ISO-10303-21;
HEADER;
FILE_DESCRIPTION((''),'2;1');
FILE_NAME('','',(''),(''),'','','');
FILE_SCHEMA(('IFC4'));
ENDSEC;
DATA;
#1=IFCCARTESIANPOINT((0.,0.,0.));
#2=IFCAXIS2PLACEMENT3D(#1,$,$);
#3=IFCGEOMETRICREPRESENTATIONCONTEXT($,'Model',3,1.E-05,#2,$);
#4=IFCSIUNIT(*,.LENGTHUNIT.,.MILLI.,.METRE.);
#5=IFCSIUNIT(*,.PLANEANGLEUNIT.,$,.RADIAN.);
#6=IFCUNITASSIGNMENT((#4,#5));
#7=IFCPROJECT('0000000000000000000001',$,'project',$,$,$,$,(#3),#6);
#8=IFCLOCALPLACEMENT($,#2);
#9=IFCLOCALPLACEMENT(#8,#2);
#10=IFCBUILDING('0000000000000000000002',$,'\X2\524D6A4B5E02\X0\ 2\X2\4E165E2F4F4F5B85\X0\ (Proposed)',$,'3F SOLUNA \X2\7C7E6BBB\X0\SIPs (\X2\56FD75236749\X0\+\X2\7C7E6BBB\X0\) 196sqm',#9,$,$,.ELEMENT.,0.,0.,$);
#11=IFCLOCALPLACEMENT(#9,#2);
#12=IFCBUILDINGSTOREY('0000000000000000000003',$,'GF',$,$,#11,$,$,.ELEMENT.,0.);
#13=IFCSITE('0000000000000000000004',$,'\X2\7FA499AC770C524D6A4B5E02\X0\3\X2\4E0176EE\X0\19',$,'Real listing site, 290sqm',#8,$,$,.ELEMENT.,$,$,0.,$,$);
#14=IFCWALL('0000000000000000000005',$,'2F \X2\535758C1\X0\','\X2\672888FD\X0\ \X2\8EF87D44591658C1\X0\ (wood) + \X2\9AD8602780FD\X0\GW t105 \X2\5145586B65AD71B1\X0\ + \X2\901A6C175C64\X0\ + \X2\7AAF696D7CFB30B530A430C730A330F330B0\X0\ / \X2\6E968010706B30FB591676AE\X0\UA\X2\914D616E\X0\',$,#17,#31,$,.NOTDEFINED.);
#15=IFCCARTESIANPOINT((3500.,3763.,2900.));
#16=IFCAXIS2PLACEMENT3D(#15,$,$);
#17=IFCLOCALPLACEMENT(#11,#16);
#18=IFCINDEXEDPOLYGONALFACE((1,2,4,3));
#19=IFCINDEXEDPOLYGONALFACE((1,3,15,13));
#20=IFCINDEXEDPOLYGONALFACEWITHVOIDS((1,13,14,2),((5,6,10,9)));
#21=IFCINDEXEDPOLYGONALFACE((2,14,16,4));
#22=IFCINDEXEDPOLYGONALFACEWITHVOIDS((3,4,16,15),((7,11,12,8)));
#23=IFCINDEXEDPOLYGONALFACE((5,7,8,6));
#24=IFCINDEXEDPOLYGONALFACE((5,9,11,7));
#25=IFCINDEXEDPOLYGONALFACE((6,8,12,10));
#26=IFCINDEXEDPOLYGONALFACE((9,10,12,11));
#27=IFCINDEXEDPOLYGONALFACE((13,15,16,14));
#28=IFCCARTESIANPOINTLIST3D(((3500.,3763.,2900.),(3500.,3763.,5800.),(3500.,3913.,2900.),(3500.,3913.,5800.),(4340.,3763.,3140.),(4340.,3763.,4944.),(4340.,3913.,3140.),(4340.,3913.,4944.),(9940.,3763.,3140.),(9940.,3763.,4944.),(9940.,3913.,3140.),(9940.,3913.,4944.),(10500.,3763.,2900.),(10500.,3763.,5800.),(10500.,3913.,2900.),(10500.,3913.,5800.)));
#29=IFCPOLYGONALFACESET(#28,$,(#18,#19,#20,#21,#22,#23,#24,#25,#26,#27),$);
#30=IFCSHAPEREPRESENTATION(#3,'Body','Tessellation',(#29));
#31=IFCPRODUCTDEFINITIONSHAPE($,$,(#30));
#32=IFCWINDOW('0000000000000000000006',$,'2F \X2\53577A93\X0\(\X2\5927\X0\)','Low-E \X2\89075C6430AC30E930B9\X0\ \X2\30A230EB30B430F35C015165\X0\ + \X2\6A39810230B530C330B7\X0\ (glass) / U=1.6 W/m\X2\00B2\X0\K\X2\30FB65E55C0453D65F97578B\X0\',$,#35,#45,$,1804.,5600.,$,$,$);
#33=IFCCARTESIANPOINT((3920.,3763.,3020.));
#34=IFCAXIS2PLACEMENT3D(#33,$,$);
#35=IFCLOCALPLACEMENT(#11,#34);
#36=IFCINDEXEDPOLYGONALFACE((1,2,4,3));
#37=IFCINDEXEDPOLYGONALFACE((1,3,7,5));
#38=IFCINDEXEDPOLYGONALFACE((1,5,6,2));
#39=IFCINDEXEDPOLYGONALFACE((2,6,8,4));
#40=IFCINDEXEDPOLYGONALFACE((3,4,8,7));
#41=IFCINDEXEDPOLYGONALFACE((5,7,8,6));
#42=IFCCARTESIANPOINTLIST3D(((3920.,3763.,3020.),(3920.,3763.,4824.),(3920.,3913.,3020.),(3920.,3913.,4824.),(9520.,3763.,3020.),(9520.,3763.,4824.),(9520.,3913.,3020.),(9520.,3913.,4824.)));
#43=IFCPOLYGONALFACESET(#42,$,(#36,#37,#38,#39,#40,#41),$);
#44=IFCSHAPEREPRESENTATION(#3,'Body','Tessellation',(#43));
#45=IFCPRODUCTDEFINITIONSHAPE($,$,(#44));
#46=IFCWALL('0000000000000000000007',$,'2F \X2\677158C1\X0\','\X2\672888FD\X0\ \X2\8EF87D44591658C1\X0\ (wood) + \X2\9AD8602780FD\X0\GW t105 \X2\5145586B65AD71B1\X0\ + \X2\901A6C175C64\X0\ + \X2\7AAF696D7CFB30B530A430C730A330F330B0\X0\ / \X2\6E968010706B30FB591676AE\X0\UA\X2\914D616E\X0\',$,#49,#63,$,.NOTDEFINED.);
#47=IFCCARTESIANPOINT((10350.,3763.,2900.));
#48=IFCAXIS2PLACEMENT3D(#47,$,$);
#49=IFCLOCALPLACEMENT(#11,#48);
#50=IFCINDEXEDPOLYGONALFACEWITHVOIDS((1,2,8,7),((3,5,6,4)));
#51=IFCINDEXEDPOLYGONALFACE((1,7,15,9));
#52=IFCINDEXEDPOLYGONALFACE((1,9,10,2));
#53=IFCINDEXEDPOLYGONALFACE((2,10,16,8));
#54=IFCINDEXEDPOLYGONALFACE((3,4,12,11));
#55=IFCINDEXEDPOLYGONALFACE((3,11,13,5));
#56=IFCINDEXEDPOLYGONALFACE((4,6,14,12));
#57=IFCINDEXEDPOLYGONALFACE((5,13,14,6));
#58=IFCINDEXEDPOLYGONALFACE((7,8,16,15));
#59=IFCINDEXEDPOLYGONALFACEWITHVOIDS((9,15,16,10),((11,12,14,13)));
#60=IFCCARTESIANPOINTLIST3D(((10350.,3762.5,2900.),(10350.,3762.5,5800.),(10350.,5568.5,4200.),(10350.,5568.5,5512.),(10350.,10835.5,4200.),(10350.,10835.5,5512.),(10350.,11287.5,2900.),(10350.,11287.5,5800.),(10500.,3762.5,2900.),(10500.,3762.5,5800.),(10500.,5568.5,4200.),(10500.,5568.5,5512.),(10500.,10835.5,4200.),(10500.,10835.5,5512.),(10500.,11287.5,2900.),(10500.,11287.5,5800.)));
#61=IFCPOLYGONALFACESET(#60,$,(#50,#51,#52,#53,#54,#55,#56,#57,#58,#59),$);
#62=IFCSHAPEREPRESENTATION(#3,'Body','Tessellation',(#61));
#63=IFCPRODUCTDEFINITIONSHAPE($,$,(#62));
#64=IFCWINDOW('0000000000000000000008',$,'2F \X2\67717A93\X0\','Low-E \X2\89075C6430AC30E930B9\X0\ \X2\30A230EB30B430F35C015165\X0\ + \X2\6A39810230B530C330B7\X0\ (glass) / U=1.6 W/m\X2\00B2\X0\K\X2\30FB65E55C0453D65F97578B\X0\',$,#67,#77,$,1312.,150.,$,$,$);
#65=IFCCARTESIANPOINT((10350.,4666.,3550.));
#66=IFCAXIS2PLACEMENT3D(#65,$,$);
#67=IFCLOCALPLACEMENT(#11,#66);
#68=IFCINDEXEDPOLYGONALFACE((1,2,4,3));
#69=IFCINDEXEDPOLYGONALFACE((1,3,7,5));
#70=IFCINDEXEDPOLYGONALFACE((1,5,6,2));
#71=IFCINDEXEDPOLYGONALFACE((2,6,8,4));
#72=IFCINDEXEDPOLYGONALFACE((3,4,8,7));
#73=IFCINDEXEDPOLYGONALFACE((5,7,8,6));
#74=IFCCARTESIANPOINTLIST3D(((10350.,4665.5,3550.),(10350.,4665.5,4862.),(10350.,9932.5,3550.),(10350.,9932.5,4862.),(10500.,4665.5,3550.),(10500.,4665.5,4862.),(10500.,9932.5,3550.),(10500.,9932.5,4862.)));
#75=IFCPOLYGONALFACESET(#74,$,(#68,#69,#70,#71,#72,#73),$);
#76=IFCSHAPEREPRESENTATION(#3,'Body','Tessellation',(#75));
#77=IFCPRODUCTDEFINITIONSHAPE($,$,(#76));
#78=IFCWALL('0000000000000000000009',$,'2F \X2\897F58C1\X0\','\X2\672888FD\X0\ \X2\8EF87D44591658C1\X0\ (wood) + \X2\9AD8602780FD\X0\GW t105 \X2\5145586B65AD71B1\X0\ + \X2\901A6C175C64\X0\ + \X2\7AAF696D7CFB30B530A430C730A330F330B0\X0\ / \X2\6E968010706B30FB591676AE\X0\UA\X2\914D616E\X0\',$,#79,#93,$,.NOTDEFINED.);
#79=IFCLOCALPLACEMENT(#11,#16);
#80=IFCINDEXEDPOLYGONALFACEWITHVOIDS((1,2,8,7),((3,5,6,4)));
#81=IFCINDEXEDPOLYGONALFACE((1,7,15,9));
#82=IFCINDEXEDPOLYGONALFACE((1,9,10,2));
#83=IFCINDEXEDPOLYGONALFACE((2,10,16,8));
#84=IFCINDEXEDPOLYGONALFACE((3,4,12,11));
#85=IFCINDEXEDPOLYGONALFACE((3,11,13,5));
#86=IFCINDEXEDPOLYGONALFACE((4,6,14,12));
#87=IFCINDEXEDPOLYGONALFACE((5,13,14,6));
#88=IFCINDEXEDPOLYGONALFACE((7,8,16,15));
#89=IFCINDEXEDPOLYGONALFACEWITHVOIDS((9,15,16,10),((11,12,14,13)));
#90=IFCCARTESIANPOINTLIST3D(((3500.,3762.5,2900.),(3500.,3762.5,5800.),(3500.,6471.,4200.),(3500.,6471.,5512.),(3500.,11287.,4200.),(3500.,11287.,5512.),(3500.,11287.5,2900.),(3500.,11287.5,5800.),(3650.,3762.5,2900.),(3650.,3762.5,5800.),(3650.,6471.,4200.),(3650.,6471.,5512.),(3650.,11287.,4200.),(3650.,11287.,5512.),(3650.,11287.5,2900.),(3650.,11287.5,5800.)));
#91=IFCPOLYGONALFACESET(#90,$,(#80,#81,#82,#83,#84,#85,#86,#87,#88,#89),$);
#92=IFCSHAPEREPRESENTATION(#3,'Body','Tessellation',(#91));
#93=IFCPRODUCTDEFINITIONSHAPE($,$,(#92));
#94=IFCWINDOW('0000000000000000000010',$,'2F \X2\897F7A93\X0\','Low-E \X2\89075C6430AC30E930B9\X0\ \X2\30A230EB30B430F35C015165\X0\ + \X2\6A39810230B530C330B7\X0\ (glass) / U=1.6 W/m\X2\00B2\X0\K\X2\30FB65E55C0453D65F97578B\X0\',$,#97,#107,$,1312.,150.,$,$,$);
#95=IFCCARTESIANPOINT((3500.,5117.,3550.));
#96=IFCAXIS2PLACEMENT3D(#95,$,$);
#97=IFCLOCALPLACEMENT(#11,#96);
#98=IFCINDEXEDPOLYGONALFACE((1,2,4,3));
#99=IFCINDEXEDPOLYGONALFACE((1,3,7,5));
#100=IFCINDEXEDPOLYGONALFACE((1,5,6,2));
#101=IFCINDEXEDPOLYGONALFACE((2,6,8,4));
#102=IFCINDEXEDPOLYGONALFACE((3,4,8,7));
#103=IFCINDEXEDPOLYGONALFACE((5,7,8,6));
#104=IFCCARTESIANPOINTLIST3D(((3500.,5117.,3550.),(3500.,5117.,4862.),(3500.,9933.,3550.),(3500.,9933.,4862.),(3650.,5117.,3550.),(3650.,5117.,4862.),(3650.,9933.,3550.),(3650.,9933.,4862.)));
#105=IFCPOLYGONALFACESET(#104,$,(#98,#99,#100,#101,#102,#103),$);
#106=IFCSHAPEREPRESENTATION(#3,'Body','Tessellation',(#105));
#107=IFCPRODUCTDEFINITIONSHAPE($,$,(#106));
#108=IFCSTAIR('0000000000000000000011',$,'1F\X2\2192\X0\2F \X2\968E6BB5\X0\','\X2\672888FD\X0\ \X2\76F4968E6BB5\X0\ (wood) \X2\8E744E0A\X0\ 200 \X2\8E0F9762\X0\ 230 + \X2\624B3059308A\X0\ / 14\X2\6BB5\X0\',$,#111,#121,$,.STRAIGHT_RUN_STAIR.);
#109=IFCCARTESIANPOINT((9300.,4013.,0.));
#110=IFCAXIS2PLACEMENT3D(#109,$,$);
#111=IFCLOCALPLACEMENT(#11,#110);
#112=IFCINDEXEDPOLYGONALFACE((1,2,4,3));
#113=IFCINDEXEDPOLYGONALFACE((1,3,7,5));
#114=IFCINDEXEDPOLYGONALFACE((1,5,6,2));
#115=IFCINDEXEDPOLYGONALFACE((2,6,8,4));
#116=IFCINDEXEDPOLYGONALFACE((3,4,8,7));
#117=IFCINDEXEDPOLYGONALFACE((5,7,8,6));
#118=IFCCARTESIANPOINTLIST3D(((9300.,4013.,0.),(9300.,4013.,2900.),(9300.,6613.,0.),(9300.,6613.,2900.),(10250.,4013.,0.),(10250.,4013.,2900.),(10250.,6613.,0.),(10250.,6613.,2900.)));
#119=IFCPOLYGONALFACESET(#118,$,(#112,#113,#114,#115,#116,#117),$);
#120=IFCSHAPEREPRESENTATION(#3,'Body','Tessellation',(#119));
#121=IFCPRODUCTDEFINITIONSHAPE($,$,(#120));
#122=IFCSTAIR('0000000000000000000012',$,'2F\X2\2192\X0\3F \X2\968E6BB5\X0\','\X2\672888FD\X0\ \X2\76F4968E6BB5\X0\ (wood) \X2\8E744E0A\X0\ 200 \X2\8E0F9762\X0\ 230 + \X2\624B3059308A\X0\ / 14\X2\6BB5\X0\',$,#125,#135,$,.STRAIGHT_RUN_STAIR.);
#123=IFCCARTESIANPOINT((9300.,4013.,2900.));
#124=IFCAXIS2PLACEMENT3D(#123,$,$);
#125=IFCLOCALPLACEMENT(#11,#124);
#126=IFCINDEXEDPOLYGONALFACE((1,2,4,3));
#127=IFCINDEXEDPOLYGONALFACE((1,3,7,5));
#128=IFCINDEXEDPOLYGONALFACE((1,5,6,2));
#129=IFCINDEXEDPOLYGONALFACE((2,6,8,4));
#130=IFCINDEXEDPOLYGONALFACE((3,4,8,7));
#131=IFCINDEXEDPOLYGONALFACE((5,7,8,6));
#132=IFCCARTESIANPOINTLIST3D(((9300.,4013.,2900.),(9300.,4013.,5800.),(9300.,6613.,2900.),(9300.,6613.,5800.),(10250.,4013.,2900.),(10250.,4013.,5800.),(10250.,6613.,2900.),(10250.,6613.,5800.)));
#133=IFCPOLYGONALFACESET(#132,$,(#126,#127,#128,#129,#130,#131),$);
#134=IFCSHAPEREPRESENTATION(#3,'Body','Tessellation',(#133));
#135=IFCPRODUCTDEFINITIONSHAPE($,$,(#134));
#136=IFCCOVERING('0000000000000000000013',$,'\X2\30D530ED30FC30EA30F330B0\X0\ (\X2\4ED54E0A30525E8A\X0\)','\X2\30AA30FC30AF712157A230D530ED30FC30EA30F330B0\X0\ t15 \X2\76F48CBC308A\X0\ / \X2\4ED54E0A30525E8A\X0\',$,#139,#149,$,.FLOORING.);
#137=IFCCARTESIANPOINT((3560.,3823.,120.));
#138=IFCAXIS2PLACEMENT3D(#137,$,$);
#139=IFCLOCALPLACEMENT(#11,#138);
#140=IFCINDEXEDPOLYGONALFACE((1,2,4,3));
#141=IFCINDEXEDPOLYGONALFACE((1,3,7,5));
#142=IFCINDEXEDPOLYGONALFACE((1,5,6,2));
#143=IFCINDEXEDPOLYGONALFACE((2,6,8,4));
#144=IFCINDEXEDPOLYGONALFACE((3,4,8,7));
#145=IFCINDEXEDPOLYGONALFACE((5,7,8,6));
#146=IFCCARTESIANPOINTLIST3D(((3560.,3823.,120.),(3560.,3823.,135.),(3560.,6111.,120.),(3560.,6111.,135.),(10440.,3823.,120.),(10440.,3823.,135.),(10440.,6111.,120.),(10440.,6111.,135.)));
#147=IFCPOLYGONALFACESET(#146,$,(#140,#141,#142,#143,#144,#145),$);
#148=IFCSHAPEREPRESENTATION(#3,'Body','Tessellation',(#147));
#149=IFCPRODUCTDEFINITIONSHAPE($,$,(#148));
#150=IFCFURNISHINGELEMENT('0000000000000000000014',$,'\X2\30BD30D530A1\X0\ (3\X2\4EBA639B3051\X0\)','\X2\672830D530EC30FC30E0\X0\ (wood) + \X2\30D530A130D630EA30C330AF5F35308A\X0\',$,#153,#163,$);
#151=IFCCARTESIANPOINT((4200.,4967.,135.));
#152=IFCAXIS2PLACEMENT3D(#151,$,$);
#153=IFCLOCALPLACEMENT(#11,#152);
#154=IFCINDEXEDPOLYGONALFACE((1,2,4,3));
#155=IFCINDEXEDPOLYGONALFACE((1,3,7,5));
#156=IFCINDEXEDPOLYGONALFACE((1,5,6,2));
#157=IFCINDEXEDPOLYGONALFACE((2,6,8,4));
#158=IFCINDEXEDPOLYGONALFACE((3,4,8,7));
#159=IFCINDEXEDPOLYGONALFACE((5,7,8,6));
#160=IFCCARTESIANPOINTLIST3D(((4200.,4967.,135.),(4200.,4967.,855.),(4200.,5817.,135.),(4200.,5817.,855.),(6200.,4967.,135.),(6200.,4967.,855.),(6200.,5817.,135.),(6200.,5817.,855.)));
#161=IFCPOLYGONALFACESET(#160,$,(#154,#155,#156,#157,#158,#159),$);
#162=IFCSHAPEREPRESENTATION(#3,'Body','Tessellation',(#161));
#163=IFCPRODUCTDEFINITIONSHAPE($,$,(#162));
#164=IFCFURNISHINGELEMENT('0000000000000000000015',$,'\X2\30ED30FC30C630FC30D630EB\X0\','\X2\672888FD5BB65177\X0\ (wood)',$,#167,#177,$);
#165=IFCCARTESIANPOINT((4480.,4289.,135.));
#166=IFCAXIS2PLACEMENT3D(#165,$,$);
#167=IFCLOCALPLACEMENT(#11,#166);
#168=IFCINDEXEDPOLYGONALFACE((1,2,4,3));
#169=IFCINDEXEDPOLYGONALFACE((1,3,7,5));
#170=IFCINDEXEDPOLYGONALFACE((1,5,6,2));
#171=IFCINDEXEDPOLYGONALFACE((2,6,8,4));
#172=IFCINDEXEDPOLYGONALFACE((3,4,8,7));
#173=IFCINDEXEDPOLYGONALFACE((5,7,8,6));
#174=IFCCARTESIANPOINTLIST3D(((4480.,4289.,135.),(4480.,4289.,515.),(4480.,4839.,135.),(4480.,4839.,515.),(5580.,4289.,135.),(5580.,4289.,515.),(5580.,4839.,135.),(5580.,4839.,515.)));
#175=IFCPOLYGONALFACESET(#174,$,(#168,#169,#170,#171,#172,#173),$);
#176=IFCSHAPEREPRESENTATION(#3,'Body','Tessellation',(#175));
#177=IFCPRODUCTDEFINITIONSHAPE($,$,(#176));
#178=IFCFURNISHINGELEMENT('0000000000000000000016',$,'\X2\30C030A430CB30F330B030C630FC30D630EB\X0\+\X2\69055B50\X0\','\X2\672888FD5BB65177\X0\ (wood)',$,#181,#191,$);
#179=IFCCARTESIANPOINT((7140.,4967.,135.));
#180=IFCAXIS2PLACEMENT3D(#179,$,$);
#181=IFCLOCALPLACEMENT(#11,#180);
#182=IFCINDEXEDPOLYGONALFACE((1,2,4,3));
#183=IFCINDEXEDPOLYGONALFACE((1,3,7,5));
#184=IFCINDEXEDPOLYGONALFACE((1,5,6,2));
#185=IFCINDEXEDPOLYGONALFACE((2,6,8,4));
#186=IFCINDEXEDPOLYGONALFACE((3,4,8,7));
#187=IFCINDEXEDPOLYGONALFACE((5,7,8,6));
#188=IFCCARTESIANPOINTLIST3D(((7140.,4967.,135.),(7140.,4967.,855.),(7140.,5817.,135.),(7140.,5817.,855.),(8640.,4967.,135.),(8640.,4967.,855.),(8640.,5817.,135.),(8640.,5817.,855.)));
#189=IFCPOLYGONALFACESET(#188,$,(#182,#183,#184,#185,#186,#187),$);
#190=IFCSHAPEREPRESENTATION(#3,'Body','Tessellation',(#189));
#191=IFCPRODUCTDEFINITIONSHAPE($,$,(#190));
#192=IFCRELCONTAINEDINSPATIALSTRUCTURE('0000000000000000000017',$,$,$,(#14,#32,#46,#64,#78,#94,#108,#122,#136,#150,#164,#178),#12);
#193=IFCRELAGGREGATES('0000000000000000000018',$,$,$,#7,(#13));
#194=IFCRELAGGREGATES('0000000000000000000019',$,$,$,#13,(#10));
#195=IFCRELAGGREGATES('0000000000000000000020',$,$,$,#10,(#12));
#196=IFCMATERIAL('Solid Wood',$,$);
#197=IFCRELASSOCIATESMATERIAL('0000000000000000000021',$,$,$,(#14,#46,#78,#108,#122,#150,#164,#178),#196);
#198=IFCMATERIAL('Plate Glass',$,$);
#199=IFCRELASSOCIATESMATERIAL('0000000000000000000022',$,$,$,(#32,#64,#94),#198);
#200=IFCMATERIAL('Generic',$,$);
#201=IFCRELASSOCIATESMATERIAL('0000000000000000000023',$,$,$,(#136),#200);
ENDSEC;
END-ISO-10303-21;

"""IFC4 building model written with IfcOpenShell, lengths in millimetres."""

from ifc_helpers import new_model, si_unit, frame, frame_2d, origin, place, context, project, spatial, rectangle, extrude, material, element, fill, save


model = new_model("IFC4")

# Units and contexts
model_context = context("Model", 3, precision=1e-05, world=origin())
ifc_project = project(units=[si_unit("LENGTHUNIT", "METRE", prefix="MILLI"), si_unit("PLANEANGLEUNIT", "RADIAN")], contexts=[model_context])

# Site, building, storey
site_placement = place(None, origin())
site = spatial("IfcSite", under=ifc_project, at=site_placement, Name="群馬県前橋市3丁目19", ObjectType="Real listing site, 290sqm", CompositionType="ELEMENT", RefElevation=0.0)
building_placement = place(site_placement, origin())
building = spatial("IfcBuilding", under=site, at=building_placement, Name="前橋市 2世帯住宅 (Proposed)", ObjectType="3F SOLUNA 籾殻SIPs (国産杉+籾殻) 196sqm", CompositionType="ELEMENT", ElevationOfRefHeight=0.0, ElevationOfTerrain=0.0)
storey_placement = place(building_placement, origin())
storey = spatial("IfcBuildingStorey", under=building, at=storey_placement, Name="GF", CompositionType="ELEMENT", Elevation=0.0)

# Shared definitions
ifc_material_1 = material(Name="Solid Wood")

# Shared definitions
ifc_material_2 = material(Name="Plate Glass")

# Walls, openings, windows
wall_1_placement = place(storey_placement, frame((3500.0, 3763.0, 2900.0)))
wall_1 = element("IfcWall", 1, at=wall_1_placement, inside=storey, material=ifc_material_1, Name="2F 南壁", Description="木製 軸組外壁 (wood) + 高性能GW t105 充填断熱 + 通気層 + 窯業系サイディング / 準耐火・外皮UA配慮", PredefinedType="NOTDEFINED", context=model_context, shape_type="SweptSolid", body=[
    extrude(rectangle(XDim=7000.0, YDim=150.0, at=frame_2d((3500.0, 75.0))), frame((3500.0, 3763.0, 2900.0)), (0.0, 0.0, 1.0), 2900.0),
])
opening_1_placement = place(storey_placement, frame((3920.0, 3763.0, 3020.0)))
opening_1 = element("IfcOpeningElement", 2, at=opening_1_placement, cuts=wall_1, PredefinedType="NOTDEFINED", context=model_context, shape_type="SweptSolid", body=[
    extrude(rectangle(XDim=5600.0, YDim=150.0, at=frame_2d((2800.0, 75.0))), frame((3920.0, 3763.0, 3020.0)), (0.0, 0.0, 1.0), 1804.0),
])
window_1_placement = place(storey_placement, frame((3920.0, 3763.0, 3020.0)))
window_1 = element("IfcWindow", 3, at=window_1_placement, inside=storey, material=ifc_material_2, Name="2F 南窓(大)", Description="Low-E 複層ガラス アルゴン封入 + 樹脂サッシ (glass) / U=1.6 W/m²K・日射取得型", OverallHeight=1804.0, OverallWidth=5600.0, context=model_context, shape_type="SweptSolid", body=[
    extrude(rectangle(XDim=5600.0, YDim=150.0, at=frame_2d((2800.0, 75.0))), frame((3920.0, 3763.0, 3020.0)), (0.0, 0.0, 1.0), 1804.0),
])
fill(opening_1, window_1)
wall_2_placement = place(storey_placement, frame((10350.0, 3763.0, 2900.0)))
wall_2 = element("IfcWall", 4, at=wall_2_placement, inside=storey, material=ifc_material_1, Name="2F 東壁", Description="木製 軸組外壁 (wood) + 高性能GW t105 充填断熱 + 通気層 + 窯業系サイディング / 準耐火・外皮UA配慮", PredefinedType="NOTDEFINED", context=model_context, shape_type="SweptSolid", body=[
    extrude(rectangle(XDim=150.0, YDim=7525.0, at=frame_2d((75.0, 3762.0))), frame((10350.0, 3763.0, 2900.0)), (0.0, 0.0, 1.0), 2900.0),
])
opening_2_placement = place(storey_placement, frame((10350.0, 4666.0, 3550.0)))
opening_2 = element("IfcOpeningElement", 5, at=opening_2_placement, cuts=wall_2, PredefinedType="NOTDEFINED", context=model_context, shape_type="SweptSolid", body=[
    extrude(rectangle(XDim=150.0, YDim=5267.0, at=frame_2d((75.0, 2633.0))), frame((10350.0, 4666.0, 3550.0)), (0.0, 0.0, 1.0), 1312.0),
])
window_2_placement = place(storey_placement, frame((10350.0, 4666.0, 3550.0)))
window_2 = element("IfcWindow", 6, at=window_2_placement, inside=storey, material=ifc_material_2, Name="2F 東窓", Description="Low-E 複層ガラス アルゴン封入 + 樹脂サッシ (glass) / U=1.6 W/m²K・日射取得型", OverallHeight=1312.0, OverallWidth=150.0, context=model_context, shape_type="SweptSolid", body=[
    extrude(rectangle(XDim=150.0, YDim=5267.0, at=frame_2d((75.0, 2633.0))), frame((10350.0, 4666.0, 3550.0)), (0.0, 0.0, 1.0), 1312.0),
])
fill(opening_2, window_2)
wall_3_placement = place(storey_placement, frame((3500.0, 3763.0, 2900.0)))
wall_3 = element("IfcWall", 7, at=wall_3_placement, inside=storey, material=ifc_material_1, Name="2F 西壁", Description="木製 軸組外壁 (wood) + 高性能GW t105 充填断熱 + 通気層 + 窯業系サイディング / 準耐火・外皮UA配慮", PredefinedType="NOTDEFINED", context=model_context, shape_type="SweptSolid", body=[
    extrude(rectangle(XDim=150.0, YDim=7525.0, at=frame_2d((75.0, 3762.0))), frame((3500.0, 3763.0, 2900.0)), (0.0, 0.0, 1.0), 2900.0),
])
opening_3_placement = place(storey_placement, frame((3500.0, 5117.0, 3550.0)))
opening_3 = element("IfcOpeningElement", 8, at=opening_3_placement, cuts=wall_3, PredefinedType="NOTDEFINED", context=model_context, shape_type="SweptSolid", body=[
    extrude(rectangle(XDim=150.0, YDim=4816.0, at=frame_2d((75.0, 2408.0))), frame((3500.0, 5117.0, 3550.0)), (0.0, 0.0, 1.0), 1312.0),
])
window_3_placement = place(storey_placement, frame((3500.0, 5117.0, 3550.0)))
window_3 = element("IfcWindow", 9, at=window_3_placement, inside=storey, material=ifc_material_2, Name="2F 西窓", Description="Low-E 複層ガラス アルゴン封入 + 樹脂サッシ (glass) / U=1.6 W/m²K・日射取得型", OverallHeight=1312.0, OverallWidth=150.0, context=model_context, shape_type="SweptSolid", body=[
    extrude(rectangle(XDim=150.0, YDim=4816.0, at=frame_2d((75.0, 2408.0))), frame((3500.0, 5117.0, 3550.0)), (0.0, 0.0, 1.0), 1312.0),
])
fill(opening_3, window_3)

# Stairs
stair_1_placement = place(storey_placement, frame((9300.0, 4013.0, 0.0)))
element("IfcStair", 10, at=stair_1_placement, inside=storey, material=ifc_material_1, Name="1F→2F 階段", Description="木製 直階段 (wood) 蹴上 200 踏面 230 + 手すり / 14段", PredefinedType="STRAIGHT_RUN_STAIR", context=model_context, shape_type="SweptSolid", body=[
    extrude(rectangle(XDim=950.0, YDim=2600.0, at=frame_2d((475.0, 1300.0))), frame((9300.0, 4013.0, 0.0)), (0.0, 0.0, 1.0), 2900.0),
])
stair_2_placement = place(storey_placement, frame((9300.0, 4013.0, 2900.0)))
element("IfcStair", 11, at=stair_2_placement, inside=storey, material=ifc_material_1, Name="2F→3F 階段", Description="木製 直階段 (wood) 蹴上 200 踏面 230 + 手すり / 14段", PredefinedType="STRAIGHT_RUN_STAIR", context=model_context, shape_type="SweptSolid", body=[
    extrude(rectangle(XDim=950.0, YDim=2600.0, at=frame_2d((475.0, 1300.0))), frame((9300.0, 4013.0, 2900.0)), (0.0, 0.0, 1.0), 2900.0),
])

# Covering
ifc_material_3 = material(Name="Generic")
covering_placement = place(storey_placement, frame((3560.0, 3823.0, 120.0)))
element("IfcCovering", 12, at=covering_placement, inside=storey, material=ifc_material_3, Name="フローリング (仕上げ床)", Description="オーク無垢フローリング t15 直貼り / 仕上げ床", PredefinedType="FLOORING", context=model_context, shape_type="SweptSolid", body=[
    extrude(rectangle(XDim=6880.0, YDim=2288.0, at=frame_2d((3440.0, 1144.0))), frame((3560.0, 3823.0, 120.0)), (0.0, 0.0, 1.0), 15.0),
])

# Furnishing elements
furnishing_1_placement = place(storey_placement, frame((4200.0, 4967.0, 135.0)))
element("IfcFurnishingElement", 13, at=furnishing_1_placement, inside=storey, material=ifc_material_1, Name="ソファ (3人掛け)", Description="木フレーム (wood) + ファブリック張り", context=model_context, shape_type="SweptSolid", body=[
    extrude(rectangle(XDim=2000.0, YDim=850.0, at=frame_2d((1000.0, 425.0))), frame((4200.0, 4967.0, 135.0)), (0.0, 0.0, 1.0), 720.0),
])
furnishing_2_placement = place(storey_placement, frame((4480.0, 4289.0, 135.0)))
element("IfcFurnishingElement", 14, at=furnishing_2_placement, inside=storey, material=ifc_material_1, Name="ローテーブル", Description="木製家具 (wood)", context=model_context, shape_type="SweptSolid", body=[
    extrude(rectangle(XDim=1100.0, YDim=550.0, at=frame_2d((550.0, 275.0))), frame((4480.0, 4289.0, 135.0)), (0.0, 0.0, 1.0), 380.0),
])
furnishing_3_placement = place(storey_placement, frame((7140.0, 4967.0, 135.0)))
element("IfcFurnishingElement", 15, at=furnishing_3_placement, inside=storey, material=ifc_material_1, Name="ダイニングテーブル+椅子", Description="木製家具 (wood)", context=model_context, shape_type="SweptSolid", body=[
    extrude(rectangle(XDim=1500.0, YDim=850.0, at=frame_2d((750.0, 425.0))), frame((7140.0, 4967.0, 135.0)), (0.0, 0.0, 1.0), 720.0),
])

save(model, "model.ifc")
